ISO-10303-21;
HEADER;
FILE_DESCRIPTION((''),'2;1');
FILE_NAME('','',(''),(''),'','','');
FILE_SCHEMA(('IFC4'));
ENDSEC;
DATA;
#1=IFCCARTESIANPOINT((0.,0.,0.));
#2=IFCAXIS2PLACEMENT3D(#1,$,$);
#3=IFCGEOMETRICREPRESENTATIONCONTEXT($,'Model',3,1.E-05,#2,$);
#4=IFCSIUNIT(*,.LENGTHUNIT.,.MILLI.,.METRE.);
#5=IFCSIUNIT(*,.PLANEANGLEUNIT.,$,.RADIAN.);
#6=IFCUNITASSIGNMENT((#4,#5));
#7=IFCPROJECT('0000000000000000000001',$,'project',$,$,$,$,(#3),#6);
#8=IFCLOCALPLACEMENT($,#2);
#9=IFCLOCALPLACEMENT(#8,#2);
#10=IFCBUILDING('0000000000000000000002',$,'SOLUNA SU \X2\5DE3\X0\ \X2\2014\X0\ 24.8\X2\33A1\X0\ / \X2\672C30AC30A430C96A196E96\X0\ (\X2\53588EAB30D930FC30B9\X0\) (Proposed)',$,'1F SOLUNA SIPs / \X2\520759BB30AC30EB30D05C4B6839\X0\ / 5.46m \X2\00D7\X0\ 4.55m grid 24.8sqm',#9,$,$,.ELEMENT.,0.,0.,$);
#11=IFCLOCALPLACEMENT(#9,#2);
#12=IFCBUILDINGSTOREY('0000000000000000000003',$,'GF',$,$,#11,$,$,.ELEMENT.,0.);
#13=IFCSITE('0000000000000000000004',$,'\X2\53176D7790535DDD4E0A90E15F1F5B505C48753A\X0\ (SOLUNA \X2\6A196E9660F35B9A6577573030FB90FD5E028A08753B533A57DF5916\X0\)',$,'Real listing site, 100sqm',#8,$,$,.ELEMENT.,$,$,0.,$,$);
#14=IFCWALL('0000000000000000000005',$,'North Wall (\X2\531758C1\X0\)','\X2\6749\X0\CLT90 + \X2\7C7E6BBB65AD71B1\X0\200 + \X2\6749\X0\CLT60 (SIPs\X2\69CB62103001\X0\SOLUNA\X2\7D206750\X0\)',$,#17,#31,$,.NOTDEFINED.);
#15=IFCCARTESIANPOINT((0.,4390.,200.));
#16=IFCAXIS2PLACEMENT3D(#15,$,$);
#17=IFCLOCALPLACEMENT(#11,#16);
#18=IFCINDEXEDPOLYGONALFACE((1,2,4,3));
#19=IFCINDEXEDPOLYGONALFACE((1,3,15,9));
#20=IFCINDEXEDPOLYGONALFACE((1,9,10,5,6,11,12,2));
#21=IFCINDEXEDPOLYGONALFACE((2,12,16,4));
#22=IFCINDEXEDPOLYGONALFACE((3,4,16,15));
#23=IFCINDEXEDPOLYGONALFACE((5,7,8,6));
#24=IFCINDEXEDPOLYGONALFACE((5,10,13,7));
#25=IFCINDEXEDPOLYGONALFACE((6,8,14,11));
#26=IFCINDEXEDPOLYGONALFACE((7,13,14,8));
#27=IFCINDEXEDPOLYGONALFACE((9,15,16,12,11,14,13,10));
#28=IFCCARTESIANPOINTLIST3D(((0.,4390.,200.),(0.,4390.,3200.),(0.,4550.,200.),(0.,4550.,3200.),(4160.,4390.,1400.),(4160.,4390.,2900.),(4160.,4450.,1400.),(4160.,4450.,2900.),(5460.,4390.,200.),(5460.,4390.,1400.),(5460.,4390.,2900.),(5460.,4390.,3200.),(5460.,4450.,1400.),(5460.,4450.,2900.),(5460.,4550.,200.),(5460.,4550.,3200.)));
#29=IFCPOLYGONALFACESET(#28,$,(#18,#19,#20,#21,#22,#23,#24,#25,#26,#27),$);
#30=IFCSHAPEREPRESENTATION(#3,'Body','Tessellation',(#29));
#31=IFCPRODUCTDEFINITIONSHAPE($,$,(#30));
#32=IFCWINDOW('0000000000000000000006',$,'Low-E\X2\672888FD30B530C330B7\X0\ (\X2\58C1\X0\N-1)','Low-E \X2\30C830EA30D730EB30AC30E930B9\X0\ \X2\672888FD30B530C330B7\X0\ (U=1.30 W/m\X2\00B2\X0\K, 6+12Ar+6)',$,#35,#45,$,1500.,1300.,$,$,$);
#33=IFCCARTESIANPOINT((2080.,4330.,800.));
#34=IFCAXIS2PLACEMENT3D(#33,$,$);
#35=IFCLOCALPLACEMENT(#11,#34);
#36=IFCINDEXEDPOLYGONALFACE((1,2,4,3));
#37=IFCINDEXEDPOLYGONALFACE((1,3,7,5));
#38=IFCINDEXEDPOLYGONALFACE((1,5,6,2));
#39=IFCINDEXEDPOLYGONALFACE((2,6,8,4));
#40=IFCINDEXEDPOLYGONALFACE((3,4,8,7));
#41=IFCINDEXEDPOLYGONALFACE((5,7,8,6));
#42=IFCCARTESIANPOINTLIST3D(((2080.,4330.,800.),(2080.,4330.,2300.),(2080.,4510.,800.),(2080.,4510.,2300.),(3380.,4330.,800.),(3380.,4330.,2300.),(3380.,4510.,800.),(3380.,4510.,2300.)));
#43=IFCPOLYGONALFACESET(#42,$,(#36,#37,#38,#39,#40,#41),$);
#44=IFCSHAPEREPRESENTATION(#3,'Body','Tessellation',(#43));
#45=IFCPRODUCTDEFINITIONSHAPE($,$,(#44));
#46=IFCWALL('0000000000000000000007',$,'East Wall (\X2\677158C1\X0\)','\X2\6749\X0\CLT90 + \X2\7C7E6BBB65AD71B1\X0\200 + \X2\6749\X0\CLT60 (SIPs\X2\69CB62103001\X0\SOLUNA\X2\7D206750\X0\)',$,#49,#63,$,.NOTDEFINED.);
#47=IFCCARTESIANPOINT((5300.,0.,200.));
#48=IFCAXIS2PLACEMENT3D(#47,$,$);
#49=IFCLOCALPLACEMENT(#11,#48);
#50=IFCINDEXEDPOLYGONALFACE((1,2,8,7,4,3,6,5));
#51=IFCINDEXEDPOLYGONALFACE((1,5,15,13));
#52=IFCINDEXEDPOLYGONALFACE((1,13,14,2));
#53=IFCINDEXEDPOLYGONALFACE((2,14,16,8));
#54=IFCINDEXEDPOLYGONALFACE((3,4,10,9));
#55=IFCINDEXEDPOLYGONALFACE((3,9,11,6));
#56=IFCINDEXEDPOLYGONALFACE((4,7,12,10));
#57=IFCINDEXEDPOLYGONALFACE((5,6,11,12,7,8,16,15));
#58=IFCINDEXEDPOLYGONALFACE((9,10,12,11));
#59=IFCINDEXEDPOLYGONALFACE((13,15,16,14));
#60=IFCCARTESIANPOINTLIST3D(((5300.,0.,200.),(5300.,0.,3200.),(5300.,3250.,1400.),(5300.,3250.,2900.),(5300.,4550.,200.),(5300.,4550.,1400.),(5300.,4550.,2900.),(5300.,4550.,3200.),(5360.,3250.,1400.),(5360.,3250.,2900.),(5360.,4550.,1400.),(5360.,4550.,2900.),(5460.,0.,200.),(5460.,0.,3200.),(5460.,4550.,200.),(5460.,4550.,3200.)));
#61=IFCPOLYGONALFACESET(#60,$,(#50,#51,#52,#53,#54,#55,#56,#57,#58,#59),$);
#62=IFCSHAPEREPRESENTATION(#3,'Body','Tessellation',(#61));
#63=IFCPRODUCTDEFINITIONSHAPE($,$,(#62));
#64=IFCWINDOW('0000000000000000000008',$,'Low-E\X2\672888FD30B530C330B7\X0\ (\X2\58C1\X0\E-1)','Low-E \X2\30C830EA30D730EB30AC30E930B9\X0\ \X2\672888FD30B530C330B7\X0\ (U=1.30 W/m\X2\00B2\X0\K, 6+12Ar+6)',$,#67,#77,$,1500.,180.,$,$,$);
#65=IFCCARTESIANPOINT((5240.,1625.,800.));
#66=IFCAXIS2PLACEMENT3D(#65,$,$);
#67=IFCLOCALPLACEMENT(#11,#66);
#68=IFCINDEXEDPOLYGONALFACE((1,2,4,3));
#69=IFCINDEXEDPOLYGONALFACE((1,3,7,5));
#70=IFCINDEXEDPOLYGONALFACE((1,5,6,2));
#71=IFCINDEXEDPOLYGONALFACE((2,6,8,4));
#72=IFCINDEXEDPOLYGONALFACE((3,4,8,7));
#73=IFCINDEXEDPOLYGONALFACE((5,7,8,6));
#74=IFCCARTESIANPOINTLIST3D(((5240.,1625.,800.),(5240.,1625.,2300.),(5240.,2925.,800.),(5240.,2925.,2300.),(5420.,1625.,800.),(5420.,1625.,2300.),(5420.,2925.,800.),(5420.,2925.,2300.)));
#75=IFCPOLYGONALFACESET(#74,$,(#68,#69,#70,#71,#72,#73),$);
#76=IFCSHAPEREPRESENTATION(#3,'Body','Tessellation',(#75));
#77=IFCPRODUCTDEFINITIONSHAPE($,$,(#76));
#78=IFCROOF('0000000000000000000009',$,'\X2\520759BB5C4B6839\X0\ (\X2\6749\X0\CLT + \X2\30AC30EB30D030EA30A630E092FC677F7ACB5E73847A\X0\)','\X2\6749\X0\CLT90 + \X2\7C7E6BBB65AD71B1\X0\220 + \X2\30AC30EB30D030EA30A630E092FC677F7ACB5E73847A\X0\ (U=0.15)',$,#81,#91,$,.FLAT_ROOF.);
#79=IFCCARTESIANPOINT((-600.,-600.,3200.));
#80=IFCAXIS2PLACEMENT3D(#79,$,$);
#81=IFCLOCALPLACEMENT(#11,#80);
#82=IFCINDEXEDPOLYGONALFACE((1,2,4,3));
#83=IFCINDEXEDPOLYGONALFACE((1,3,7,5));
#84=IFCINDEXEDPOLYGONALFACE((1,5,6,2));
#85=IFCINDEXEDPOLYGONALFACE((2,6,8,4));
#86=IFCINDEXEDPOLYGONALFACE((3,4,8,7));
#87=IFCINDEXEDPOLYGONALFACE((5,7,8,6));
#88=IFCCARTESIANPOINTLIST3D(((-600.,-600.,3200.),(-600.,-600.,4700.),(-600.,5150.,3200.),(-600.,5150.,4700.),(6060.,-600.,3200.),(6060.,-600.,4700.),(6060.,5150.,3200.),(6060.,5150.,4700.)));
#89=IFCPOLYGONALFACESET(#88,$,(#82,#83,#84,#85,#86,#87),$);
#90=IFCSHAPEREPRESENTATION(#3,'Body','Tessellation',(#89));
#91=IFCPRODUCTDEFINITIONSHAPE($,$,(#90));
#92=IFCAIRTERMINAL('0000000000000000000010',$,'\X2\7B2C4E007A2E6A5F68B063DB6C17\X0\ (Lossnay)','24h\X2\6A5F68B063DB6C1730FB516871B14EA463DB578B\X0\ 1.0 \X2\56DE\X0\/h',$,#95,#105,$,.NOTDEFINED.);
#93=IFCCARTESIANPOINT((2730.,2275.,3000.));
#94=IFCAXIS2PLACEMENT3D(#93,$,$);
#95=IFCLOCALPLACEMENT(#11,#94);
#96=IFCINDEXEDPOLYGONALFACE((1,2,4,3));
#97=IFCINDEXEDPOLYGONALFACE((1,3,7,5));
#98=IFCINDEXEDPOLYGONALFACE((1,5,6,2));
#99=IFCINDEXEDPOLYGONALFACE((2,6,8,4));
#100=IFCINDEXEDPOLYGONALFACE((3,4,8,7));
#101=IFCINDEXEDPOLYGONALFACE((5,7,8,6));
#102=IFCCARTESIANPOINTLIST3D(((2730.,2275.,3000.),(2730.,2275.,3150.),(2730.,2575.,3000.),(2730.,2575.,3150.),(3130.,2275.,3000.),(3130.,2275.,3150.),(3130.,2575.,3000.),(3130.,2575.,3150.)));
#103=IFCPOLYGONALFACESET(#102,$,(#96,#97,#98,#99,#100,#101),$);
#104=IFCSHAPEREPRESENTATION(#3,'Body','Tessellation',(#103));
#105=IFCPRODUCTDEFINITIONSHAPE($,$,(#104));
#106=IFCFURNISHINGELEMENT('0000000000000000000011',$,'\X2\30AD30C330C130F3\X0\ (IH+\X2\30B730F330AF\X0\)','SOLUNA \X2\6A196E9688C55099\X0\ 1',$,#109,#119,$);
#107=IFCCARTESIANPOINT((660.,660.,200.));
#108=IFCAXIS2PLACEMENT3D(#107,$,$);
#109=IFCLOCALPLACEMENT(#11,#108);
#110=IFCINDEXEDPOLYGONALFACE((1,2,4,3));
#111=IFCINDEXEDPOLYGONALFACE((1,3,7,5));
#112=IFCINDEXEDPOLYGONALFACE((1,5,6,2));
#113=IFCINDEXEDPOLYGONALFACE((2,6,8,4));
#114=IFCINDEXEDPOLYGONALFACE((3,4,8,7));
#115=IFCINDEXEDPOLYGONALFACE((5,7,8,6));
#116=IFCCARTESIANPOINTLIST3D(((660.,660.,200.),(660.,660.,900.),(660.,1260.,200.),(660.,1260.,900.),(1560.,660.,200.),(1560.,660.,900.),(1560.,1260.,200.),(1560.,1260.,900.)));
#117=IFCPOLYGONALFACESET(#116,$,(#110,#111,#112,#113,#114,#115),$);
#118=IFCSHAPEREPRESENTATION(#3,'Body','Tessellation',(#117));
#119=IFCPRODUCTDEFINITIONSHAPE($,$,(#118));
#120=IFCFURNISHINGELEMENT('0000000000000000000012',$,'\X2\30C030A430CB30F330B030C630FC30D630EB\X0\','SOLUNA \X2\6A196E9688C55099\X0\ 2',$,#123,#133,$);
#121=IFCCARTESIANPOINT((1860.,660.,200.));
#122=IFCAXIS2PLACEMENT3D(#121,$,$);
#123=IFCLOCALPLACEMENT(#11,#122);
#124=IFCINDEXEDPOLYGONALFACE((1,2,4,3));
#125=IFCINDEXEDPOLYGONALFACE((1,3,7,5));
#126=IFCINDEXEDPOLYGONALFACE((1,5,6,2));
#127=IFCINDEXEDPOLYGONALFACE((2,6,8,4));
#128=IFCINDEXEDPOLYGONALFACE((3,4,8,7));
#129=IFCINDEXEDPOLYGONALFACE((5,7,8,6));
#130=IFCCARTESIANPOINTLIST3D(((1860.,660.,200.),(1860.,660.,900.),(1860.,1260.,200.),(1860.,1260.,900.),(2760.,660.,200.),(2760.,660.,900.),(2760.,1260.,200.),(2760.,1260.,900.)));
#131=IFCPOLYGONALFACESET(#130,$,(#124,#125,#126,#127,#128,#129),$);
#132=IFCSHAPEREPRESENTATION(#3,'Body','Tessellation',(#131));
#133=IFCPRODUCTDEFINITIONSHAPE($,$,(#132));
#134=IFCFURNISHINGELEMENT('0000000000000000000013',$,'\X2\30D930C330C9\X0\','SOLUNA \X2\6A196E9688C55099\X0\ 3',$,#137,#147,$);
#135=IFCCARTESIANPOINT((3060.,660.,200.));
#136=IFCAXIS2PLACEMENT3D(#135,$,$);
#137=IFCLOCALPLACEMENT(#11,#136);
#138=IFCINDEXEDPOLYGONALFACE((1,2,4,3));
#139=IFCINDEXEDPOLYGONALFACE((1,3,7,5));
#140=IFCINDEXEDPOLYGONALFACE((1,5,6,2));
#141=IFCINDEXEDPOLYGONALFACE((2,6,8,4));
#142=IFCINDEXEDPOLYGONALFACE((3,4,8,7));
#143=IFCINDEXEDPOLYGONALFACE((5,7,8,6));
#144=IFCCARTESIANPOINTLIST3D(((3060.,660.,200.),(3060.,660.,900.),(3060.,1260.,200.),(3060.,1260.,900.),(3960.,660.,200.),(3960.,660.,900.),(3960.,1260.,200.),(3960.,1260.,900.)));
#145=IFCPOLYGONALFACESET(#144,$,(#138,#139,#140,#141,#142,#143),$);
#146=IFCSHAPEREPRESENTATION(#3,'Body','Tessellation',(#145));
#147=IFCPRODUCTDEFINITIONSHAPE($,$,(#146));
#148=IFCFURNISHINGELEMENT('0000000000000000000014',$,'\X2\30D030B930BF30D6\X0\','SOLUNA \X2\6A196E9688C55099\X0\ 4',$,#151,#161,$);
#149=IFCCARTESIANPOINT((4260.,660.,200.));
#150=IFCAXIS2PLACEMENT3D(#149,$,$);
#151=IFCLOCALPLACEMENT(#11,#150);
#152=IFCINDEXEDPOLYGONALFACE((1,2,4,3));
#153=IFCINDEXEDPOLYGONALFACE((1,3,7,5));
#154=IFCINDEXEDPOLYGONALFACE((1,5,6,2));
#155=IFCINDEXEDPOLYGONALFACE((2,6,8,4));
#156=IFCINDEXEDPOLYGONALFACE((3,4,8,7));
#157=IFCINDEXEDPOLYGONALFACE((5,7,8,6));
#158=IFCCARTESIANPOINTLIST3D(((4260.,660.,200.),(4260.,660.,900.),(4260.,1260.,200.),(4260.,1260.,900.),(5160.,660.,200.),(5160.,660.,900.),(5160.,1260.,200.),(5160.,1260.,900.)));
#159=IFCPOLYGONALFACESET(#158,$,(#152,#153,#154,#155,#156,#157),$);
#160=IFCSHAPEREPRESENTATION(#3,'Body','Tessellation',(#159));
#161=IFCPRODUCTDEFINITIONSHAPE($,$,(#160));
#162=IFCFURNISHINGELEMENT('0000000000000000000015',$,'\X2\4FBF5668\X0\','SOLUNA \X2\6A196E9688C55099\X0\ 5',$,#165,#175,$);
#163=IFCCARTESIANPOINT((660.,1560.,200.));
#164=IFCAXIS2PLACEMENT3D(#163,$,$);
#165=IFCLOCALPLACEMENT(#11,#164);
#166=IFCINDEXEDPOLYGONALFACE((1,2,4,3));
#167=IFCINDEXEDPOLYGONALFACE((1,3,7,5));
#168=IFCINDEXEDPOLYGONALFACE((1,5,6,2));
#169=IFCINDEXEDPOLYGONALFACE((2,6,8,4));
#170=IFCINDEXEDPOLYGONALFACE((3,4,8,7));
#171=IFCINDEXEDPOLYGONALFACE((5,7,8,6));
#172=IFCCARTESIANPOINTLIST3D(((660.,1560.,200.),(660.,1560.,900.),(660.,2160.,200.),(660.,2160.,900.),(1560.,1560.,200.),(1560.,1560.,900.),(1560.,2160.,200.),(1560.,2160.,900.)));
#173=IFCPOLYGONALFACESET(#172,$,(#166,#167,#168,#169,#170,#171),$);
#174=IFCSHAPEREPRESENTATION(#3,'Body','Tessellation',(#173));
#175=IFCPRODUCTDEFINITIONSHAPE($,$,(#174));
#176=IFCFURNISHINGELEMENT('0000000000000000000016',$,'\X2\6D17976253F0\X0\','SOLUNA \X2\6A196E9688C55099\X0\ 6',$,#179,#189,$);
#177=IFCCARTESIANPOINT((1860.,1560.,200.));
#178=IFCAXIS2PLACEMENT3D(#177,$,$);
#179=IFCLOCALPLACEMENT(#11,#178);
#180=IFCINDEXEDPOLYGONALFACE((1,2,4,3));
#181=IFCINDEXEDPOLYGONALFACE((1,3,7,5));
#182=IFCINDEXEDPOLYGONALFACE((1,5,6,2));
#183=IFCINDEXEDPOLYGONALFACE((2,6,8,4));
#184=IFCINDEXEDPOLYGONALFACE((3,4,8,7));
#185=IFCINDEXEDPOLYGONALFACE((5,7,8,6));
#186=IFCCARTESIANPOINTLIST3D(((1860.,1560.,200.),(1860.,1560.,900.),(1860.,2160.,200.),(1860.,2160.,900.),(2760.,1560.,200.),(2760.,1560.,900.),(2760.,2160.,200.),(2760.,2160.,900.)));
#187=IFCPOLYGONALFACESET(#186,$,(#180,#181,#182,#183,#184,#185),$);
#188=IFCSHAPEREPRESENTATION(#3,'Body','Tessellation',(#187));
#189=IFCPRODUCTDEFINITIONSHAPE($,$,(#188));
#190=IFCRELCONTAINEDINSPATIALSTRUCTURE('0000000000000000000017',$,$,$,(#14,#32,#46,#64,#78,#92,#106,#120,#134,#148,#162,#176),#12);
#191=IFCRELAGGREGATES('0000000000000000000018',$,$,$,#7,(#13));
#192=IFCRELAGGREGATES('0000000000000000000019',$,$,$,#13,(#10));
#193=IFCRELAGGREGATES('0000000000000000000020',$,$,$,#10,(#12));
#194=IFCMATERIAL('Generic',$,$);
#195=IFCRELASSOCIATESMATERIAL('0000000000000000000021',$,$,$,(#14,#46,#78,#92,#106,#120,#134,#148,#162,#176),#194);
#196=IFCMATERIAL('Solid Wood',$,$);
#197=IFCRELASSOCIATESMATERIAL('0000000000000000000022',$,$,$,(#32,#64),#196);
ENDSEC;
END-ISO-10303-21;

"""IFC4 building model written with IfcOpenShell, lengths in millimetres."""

from ifc_helpers import new_model, si_unit, frame, frame_2d, origin, place, context, project, spatial, rectangle, extrude, material, element, fill, save


model = new_model("IFC4")

# Units and contexts
model_context = context("Model", 3, precision=1e-05, world=origin())
ifc_project = project(units=[si_unit("LENGTHUNIT", "METRE", prefix="MILLI"), si_unit("PLANEANGLEUNIT", "RADIAN")], contexts=[model_context])

# Site, building, storey
site_placement = place(None, origin())
site = spatial("IfcSite", under=ifc_project, at=site_placement, Name="北海道川上郡弟子屈町 (SOLUNA 標準想定敷地・都市計画区域外)", ObjectType="Real listing site, 100sqm", CompositionType="ELEMENT", RefElevation=0.0)
building_placement = place(site_placement, origin())
building = spatial("IfcBuilding", under=site, at=building_placement, Name="SOLUNA SU 巣 — 24.8㎡ / 本ガイド標準 (単身ベース) (Proposed)", ObjectType="1F SOLUNA SIPs / 切妻ガルバ屋根 / 5.46m × 4.55m grid 24.8sqm", CompositionType="ELEMENT", ElevationOfRefHeight=0.0, ElevationOfTerrain=0.0)
storey_placement = place(building_placement, origin())
storey = spatial("IfcBuildingStorey", under=building, at=storey_placement, Name="GF", CompositionType="ELEMENT", Elevation=0.0)

# Shared definitions
ifc_material_1 = material(Name="Generic")

# Shared definitions
ifc_material_2 = material(Name="Solid Wood")

# Walls, openings, windows
wall_1_placement = place(storey_placement, frame((0.0, 4390.0, 200.0)))
wall_1 = element("IfcWall", 1, at=wall_1_placement, inside=storey, material=ifc_material_1, Name="North Wall (北壁)", Description="杉CLT90 + 籾殻断熱200 + 杉CLT60 (SIPs構成、SOLUNA素材)", PredefinedType="NOTDEFINED", context=model_context, shape_type="SweptSolid", body=[
    extrude(rectangle(XDim=5460.0, YDim=160.0, at=frame_2d((2730.0, 80.0))), frame((0.0, 4390.0, 200.0)), (0.0, 0.0, 1.0), 3000.0),
])
opening_1_placement = place(storey_placement, frame((2080.0, 4330.0, 800.0)))
opening_1 = element("IfcOpeningElement", 2, at=opening_1_placement, cuts=wall_1, PredefinedType="NOTDEFINED", context=model_context, shape_type="SweptSolid", body=[
    extrude(rectangle(XDim=1300.0, YDim=180.0, at=frame_2d((650.0, 90.0))), frame((2080.0, 4330.0, 800.0)), (0.0, 0.0, 1.0), 1500.0),
])
window_1_placement = place(storey_placement, frame((2080.0, 4330.0, 800.0)))
window_1 = element("IfcWindow", 3, at=window_1_placement, inside=storey, material=ifc_material_2, Name="Low-E木製サッシ (壁N-1)", Description="Low-E トリプルガラス 木製サッシ (U=1.30 W/m²K, 6+12Ar+6)", OverallHeight=1500.0, OverallWidth=1300.0, context=model_context, shape_type="SweptSolid", body=[
    extrude(rectangle(XDim=1300.0, YDim=180.0, at=frame_2d((650.0, 90.0))), frame((2080.0, 4330.0, 800.0)), (0.0, 0.0, 1.0), 1500.0),
])
fill(opening_1, window_1)
wall_2_placement = place(storey_placement, frame((5300.0, 0.0, 200.0)))
wall_2 = element("IfcWall", 4, at=wall_2_placement, inside=storey, material=ifc_material_1, Name="East Wall (東壁)", Description="杉CLT90 + 籾殻断熱200 + 杉CLT60 (SIPs構成、SOLUNA素材)", PredefinedType="NOTDEFINED", context=model_context, shape_type="SweptSolid", body=[
    extrude(rectangle(XDim=160.0, YDim=4550.0, at=frame_2d((80.0, 2275.0))), frame((5300.0, 0.0, 200.0)), (0.0, 0.0, 1.0), 3000.0),
])
opening_2_placement = place(storey_placement, frame((5240.0, 1625.0, 800.0)))
opening_2 = element("IfcOpeningElement", 5, at=opening_2_placement, cuts=wall_2, PredefinedType="NOTDEFINED", context=model_context, shape_type="SweptSolid", body=[
    extrude(rectangle(XDim=180.0, YDim=1300.0, at=frame_2d((90.0, 650.0))), frame((5240.0, 1625.0, 800.0)), (0.0, 0.0, 1.0), 1500.0),
])
window_2_placement = place(storey_placement, frame((5240.0, 1625.0, 800.0)))
window_2 = element("IfcWindow", 6, at=window_2_placement, inside=storey, material=ifc_material_2, Name="Low-E木製サッシ (壁E-1)", Description="Low-E トリプルガラス 木製サッシ (U=1.30 W/m²K, 6+12Ar+6)", OverallHeight=1500.0, OverallWidth=180.0, context=model_context, shape_type="SweptSolid", body=[
    extrude(rectangle(XDim=180.0, YDim=1300.0, at=frame_2d((90.0, 650.0))), frame((5240.0, 1625.0, 800.0)), (0.0, 0.0, 1.0), 1500.0),
])
fill(opening_2, window_2)

# Roof
roof_placement = place(storey_placement, frame((-600.0, -600.0, 3200.0)))
element("IfcRoof", 7, at=roof_placement, inside=storey, material=ifc_material_1, Name="切妻屋根 (杉CLT + ガルバリウム鋼板立平葺)", Description="杉CLT90 + 籾殻断熱220 + ガルバリウム鋼板立平葺 (U=0.15)", PredefinedType="FLAT_ROOF", context=model_context, shape_type="SweptSolid", body=[
    extrude(rectangle(XDim=6660.0, YDim=5750.0, at=frame_2d((3330.0, 2875.0))), frame((-600.0, -600.0, 3200.0)), (0.0, 0.0, 1.0), 1500.0),
])

# Air terminal
air_terminal_placement = place(storey_placement, frame((2730.0, 2275.0, 3000.0)))
element("IfcAirTerminal", 8, at=air_terminal_placement, inside=storey, material=ifc_material_1, Name="第一種機械換気 (Lossnay)", Description="24h機械換気・全熱交換型 1.0 回/h", PredefinedType="NOTDEFINED", context=model_context, shape_type="SweptSolid", body=[
    extrude(rectangle(XDim=400.0, YDim=300.0, at=frame_2d((200.0, 150.0))), frame((2730.0, 2275.0, 3000.0)), (0.0, 0.0, 1.0), 150.0),
])

# Furnishing elements
furnishing_1_placement = place(storey_placement, frame((660.0, 660.0, 200.0)))
element("IfcFurnishingElement", 9, at=furnishing_1_placement, inside=storey, material=ifc_material_1, Name="キッチン (IH+シンク)", Description="SOLUNA 標準装備 1", context=model_context, shape_type="SweptSolid", body=[
    extrude(rectangle(XDim=900.0, YDim=600.0, at=frame_2d((450.0, 300.0))), frame((660.0, 660.0, 200.0)), (0.0, 0.0, 1.0), 700.0),
])
furnishing_2_placement = place(storey_placement, frame((1860.0, 660.0, 200.0)))
element("IfcFurnishingElement", 10, at=furnishing_2_placement, inside=storey, material=ifc_material_1, Name="ダイニングテーブル", Description="SOLUNA 標準装備 2", context=model_context, shape_type="SweptSolid", body=[
    extrude(rectangle(XDim=900.0, YDim=600.0, at=frame_2d((450.0, 300.0))), frame((1860.0, 660.0, 200.0)), (0.0, 0.0, 1.0), 700.0),
])
furnishing_3_placement = place(storey_placement, frame((3060.0, 660.0, 200.0)))
element("IfcFurnishingElement", 11, at=furnishing_3_placement, inside=storey, material=ifc_material_1, Name="ベッド", Description="SOLUNA 標準装備 3", context=model_context, shape_type="SweptSolid", body=[
    extrude(rectangle(XDim=900.0, YDim=600.0, at=frame_2d((450.0, 300.0))), frame((3060.0, 660.0, 200.0)), (0.0, 0.0, 1.0), 700.0),
])
furnishing_4_placement = place(storey_placement, frame((4260.0, 660.0, 200.0)))
element("IfcFurnishingElement", 12, at=furnishing_4_placement, inside=storey, material=ifc_material_1, Name="バスタブ", Description="SOLUNA 標準装備 4", context=model_context, shape_type="SweptSolid", body=[
    extrude(rectangle(XDim=900.0, YDim=600.0, at=frame_2d((450.0, 300.0))), frame((4260.0, 660.0, 200.0)), (0.0, 0.0, 1.0), 700.0),
])
furnishing_5_placement = place(storey_placement, frame((660.0, 1560.0, 200.0)))
element("IfcFurnishingElement", 13, at=furnishing_5_placement, inside=storey, material=ifc_material_1, Name="便器", Description="SOLUNA 標準装備 5", context=model_context, shape_type="SweptSolid", body=[
    extrude(rectangle(XDim=900.0, YDim=600.0, at=frame_2d((450.0, 300.0))), frame((660.0, 1560.0, 200.0)), (0.0, 0.0, 1.0), 700.0),
])
furnishing_6_placement = place(storey_placement, frame((1860.0, 1560.0, 200.0)))
element("IfcFurnishingElement", 14, at=furnishing_6_placement, inside=storey, material=ifc_material_1, Name="洗面台", Description="SOLUNA 標準装備 6", context=model_context, shape_type="SweptSolid", body=[
    extrude(rectangle(XDim=900.0, YDim=600.0, at=frame_2d((450.0, 300.0))), frame((1860.0, 1560.0, 200.0)), (0.0, 0.0, 1.0), 700.0),
])

save(model, "model.ifc")
